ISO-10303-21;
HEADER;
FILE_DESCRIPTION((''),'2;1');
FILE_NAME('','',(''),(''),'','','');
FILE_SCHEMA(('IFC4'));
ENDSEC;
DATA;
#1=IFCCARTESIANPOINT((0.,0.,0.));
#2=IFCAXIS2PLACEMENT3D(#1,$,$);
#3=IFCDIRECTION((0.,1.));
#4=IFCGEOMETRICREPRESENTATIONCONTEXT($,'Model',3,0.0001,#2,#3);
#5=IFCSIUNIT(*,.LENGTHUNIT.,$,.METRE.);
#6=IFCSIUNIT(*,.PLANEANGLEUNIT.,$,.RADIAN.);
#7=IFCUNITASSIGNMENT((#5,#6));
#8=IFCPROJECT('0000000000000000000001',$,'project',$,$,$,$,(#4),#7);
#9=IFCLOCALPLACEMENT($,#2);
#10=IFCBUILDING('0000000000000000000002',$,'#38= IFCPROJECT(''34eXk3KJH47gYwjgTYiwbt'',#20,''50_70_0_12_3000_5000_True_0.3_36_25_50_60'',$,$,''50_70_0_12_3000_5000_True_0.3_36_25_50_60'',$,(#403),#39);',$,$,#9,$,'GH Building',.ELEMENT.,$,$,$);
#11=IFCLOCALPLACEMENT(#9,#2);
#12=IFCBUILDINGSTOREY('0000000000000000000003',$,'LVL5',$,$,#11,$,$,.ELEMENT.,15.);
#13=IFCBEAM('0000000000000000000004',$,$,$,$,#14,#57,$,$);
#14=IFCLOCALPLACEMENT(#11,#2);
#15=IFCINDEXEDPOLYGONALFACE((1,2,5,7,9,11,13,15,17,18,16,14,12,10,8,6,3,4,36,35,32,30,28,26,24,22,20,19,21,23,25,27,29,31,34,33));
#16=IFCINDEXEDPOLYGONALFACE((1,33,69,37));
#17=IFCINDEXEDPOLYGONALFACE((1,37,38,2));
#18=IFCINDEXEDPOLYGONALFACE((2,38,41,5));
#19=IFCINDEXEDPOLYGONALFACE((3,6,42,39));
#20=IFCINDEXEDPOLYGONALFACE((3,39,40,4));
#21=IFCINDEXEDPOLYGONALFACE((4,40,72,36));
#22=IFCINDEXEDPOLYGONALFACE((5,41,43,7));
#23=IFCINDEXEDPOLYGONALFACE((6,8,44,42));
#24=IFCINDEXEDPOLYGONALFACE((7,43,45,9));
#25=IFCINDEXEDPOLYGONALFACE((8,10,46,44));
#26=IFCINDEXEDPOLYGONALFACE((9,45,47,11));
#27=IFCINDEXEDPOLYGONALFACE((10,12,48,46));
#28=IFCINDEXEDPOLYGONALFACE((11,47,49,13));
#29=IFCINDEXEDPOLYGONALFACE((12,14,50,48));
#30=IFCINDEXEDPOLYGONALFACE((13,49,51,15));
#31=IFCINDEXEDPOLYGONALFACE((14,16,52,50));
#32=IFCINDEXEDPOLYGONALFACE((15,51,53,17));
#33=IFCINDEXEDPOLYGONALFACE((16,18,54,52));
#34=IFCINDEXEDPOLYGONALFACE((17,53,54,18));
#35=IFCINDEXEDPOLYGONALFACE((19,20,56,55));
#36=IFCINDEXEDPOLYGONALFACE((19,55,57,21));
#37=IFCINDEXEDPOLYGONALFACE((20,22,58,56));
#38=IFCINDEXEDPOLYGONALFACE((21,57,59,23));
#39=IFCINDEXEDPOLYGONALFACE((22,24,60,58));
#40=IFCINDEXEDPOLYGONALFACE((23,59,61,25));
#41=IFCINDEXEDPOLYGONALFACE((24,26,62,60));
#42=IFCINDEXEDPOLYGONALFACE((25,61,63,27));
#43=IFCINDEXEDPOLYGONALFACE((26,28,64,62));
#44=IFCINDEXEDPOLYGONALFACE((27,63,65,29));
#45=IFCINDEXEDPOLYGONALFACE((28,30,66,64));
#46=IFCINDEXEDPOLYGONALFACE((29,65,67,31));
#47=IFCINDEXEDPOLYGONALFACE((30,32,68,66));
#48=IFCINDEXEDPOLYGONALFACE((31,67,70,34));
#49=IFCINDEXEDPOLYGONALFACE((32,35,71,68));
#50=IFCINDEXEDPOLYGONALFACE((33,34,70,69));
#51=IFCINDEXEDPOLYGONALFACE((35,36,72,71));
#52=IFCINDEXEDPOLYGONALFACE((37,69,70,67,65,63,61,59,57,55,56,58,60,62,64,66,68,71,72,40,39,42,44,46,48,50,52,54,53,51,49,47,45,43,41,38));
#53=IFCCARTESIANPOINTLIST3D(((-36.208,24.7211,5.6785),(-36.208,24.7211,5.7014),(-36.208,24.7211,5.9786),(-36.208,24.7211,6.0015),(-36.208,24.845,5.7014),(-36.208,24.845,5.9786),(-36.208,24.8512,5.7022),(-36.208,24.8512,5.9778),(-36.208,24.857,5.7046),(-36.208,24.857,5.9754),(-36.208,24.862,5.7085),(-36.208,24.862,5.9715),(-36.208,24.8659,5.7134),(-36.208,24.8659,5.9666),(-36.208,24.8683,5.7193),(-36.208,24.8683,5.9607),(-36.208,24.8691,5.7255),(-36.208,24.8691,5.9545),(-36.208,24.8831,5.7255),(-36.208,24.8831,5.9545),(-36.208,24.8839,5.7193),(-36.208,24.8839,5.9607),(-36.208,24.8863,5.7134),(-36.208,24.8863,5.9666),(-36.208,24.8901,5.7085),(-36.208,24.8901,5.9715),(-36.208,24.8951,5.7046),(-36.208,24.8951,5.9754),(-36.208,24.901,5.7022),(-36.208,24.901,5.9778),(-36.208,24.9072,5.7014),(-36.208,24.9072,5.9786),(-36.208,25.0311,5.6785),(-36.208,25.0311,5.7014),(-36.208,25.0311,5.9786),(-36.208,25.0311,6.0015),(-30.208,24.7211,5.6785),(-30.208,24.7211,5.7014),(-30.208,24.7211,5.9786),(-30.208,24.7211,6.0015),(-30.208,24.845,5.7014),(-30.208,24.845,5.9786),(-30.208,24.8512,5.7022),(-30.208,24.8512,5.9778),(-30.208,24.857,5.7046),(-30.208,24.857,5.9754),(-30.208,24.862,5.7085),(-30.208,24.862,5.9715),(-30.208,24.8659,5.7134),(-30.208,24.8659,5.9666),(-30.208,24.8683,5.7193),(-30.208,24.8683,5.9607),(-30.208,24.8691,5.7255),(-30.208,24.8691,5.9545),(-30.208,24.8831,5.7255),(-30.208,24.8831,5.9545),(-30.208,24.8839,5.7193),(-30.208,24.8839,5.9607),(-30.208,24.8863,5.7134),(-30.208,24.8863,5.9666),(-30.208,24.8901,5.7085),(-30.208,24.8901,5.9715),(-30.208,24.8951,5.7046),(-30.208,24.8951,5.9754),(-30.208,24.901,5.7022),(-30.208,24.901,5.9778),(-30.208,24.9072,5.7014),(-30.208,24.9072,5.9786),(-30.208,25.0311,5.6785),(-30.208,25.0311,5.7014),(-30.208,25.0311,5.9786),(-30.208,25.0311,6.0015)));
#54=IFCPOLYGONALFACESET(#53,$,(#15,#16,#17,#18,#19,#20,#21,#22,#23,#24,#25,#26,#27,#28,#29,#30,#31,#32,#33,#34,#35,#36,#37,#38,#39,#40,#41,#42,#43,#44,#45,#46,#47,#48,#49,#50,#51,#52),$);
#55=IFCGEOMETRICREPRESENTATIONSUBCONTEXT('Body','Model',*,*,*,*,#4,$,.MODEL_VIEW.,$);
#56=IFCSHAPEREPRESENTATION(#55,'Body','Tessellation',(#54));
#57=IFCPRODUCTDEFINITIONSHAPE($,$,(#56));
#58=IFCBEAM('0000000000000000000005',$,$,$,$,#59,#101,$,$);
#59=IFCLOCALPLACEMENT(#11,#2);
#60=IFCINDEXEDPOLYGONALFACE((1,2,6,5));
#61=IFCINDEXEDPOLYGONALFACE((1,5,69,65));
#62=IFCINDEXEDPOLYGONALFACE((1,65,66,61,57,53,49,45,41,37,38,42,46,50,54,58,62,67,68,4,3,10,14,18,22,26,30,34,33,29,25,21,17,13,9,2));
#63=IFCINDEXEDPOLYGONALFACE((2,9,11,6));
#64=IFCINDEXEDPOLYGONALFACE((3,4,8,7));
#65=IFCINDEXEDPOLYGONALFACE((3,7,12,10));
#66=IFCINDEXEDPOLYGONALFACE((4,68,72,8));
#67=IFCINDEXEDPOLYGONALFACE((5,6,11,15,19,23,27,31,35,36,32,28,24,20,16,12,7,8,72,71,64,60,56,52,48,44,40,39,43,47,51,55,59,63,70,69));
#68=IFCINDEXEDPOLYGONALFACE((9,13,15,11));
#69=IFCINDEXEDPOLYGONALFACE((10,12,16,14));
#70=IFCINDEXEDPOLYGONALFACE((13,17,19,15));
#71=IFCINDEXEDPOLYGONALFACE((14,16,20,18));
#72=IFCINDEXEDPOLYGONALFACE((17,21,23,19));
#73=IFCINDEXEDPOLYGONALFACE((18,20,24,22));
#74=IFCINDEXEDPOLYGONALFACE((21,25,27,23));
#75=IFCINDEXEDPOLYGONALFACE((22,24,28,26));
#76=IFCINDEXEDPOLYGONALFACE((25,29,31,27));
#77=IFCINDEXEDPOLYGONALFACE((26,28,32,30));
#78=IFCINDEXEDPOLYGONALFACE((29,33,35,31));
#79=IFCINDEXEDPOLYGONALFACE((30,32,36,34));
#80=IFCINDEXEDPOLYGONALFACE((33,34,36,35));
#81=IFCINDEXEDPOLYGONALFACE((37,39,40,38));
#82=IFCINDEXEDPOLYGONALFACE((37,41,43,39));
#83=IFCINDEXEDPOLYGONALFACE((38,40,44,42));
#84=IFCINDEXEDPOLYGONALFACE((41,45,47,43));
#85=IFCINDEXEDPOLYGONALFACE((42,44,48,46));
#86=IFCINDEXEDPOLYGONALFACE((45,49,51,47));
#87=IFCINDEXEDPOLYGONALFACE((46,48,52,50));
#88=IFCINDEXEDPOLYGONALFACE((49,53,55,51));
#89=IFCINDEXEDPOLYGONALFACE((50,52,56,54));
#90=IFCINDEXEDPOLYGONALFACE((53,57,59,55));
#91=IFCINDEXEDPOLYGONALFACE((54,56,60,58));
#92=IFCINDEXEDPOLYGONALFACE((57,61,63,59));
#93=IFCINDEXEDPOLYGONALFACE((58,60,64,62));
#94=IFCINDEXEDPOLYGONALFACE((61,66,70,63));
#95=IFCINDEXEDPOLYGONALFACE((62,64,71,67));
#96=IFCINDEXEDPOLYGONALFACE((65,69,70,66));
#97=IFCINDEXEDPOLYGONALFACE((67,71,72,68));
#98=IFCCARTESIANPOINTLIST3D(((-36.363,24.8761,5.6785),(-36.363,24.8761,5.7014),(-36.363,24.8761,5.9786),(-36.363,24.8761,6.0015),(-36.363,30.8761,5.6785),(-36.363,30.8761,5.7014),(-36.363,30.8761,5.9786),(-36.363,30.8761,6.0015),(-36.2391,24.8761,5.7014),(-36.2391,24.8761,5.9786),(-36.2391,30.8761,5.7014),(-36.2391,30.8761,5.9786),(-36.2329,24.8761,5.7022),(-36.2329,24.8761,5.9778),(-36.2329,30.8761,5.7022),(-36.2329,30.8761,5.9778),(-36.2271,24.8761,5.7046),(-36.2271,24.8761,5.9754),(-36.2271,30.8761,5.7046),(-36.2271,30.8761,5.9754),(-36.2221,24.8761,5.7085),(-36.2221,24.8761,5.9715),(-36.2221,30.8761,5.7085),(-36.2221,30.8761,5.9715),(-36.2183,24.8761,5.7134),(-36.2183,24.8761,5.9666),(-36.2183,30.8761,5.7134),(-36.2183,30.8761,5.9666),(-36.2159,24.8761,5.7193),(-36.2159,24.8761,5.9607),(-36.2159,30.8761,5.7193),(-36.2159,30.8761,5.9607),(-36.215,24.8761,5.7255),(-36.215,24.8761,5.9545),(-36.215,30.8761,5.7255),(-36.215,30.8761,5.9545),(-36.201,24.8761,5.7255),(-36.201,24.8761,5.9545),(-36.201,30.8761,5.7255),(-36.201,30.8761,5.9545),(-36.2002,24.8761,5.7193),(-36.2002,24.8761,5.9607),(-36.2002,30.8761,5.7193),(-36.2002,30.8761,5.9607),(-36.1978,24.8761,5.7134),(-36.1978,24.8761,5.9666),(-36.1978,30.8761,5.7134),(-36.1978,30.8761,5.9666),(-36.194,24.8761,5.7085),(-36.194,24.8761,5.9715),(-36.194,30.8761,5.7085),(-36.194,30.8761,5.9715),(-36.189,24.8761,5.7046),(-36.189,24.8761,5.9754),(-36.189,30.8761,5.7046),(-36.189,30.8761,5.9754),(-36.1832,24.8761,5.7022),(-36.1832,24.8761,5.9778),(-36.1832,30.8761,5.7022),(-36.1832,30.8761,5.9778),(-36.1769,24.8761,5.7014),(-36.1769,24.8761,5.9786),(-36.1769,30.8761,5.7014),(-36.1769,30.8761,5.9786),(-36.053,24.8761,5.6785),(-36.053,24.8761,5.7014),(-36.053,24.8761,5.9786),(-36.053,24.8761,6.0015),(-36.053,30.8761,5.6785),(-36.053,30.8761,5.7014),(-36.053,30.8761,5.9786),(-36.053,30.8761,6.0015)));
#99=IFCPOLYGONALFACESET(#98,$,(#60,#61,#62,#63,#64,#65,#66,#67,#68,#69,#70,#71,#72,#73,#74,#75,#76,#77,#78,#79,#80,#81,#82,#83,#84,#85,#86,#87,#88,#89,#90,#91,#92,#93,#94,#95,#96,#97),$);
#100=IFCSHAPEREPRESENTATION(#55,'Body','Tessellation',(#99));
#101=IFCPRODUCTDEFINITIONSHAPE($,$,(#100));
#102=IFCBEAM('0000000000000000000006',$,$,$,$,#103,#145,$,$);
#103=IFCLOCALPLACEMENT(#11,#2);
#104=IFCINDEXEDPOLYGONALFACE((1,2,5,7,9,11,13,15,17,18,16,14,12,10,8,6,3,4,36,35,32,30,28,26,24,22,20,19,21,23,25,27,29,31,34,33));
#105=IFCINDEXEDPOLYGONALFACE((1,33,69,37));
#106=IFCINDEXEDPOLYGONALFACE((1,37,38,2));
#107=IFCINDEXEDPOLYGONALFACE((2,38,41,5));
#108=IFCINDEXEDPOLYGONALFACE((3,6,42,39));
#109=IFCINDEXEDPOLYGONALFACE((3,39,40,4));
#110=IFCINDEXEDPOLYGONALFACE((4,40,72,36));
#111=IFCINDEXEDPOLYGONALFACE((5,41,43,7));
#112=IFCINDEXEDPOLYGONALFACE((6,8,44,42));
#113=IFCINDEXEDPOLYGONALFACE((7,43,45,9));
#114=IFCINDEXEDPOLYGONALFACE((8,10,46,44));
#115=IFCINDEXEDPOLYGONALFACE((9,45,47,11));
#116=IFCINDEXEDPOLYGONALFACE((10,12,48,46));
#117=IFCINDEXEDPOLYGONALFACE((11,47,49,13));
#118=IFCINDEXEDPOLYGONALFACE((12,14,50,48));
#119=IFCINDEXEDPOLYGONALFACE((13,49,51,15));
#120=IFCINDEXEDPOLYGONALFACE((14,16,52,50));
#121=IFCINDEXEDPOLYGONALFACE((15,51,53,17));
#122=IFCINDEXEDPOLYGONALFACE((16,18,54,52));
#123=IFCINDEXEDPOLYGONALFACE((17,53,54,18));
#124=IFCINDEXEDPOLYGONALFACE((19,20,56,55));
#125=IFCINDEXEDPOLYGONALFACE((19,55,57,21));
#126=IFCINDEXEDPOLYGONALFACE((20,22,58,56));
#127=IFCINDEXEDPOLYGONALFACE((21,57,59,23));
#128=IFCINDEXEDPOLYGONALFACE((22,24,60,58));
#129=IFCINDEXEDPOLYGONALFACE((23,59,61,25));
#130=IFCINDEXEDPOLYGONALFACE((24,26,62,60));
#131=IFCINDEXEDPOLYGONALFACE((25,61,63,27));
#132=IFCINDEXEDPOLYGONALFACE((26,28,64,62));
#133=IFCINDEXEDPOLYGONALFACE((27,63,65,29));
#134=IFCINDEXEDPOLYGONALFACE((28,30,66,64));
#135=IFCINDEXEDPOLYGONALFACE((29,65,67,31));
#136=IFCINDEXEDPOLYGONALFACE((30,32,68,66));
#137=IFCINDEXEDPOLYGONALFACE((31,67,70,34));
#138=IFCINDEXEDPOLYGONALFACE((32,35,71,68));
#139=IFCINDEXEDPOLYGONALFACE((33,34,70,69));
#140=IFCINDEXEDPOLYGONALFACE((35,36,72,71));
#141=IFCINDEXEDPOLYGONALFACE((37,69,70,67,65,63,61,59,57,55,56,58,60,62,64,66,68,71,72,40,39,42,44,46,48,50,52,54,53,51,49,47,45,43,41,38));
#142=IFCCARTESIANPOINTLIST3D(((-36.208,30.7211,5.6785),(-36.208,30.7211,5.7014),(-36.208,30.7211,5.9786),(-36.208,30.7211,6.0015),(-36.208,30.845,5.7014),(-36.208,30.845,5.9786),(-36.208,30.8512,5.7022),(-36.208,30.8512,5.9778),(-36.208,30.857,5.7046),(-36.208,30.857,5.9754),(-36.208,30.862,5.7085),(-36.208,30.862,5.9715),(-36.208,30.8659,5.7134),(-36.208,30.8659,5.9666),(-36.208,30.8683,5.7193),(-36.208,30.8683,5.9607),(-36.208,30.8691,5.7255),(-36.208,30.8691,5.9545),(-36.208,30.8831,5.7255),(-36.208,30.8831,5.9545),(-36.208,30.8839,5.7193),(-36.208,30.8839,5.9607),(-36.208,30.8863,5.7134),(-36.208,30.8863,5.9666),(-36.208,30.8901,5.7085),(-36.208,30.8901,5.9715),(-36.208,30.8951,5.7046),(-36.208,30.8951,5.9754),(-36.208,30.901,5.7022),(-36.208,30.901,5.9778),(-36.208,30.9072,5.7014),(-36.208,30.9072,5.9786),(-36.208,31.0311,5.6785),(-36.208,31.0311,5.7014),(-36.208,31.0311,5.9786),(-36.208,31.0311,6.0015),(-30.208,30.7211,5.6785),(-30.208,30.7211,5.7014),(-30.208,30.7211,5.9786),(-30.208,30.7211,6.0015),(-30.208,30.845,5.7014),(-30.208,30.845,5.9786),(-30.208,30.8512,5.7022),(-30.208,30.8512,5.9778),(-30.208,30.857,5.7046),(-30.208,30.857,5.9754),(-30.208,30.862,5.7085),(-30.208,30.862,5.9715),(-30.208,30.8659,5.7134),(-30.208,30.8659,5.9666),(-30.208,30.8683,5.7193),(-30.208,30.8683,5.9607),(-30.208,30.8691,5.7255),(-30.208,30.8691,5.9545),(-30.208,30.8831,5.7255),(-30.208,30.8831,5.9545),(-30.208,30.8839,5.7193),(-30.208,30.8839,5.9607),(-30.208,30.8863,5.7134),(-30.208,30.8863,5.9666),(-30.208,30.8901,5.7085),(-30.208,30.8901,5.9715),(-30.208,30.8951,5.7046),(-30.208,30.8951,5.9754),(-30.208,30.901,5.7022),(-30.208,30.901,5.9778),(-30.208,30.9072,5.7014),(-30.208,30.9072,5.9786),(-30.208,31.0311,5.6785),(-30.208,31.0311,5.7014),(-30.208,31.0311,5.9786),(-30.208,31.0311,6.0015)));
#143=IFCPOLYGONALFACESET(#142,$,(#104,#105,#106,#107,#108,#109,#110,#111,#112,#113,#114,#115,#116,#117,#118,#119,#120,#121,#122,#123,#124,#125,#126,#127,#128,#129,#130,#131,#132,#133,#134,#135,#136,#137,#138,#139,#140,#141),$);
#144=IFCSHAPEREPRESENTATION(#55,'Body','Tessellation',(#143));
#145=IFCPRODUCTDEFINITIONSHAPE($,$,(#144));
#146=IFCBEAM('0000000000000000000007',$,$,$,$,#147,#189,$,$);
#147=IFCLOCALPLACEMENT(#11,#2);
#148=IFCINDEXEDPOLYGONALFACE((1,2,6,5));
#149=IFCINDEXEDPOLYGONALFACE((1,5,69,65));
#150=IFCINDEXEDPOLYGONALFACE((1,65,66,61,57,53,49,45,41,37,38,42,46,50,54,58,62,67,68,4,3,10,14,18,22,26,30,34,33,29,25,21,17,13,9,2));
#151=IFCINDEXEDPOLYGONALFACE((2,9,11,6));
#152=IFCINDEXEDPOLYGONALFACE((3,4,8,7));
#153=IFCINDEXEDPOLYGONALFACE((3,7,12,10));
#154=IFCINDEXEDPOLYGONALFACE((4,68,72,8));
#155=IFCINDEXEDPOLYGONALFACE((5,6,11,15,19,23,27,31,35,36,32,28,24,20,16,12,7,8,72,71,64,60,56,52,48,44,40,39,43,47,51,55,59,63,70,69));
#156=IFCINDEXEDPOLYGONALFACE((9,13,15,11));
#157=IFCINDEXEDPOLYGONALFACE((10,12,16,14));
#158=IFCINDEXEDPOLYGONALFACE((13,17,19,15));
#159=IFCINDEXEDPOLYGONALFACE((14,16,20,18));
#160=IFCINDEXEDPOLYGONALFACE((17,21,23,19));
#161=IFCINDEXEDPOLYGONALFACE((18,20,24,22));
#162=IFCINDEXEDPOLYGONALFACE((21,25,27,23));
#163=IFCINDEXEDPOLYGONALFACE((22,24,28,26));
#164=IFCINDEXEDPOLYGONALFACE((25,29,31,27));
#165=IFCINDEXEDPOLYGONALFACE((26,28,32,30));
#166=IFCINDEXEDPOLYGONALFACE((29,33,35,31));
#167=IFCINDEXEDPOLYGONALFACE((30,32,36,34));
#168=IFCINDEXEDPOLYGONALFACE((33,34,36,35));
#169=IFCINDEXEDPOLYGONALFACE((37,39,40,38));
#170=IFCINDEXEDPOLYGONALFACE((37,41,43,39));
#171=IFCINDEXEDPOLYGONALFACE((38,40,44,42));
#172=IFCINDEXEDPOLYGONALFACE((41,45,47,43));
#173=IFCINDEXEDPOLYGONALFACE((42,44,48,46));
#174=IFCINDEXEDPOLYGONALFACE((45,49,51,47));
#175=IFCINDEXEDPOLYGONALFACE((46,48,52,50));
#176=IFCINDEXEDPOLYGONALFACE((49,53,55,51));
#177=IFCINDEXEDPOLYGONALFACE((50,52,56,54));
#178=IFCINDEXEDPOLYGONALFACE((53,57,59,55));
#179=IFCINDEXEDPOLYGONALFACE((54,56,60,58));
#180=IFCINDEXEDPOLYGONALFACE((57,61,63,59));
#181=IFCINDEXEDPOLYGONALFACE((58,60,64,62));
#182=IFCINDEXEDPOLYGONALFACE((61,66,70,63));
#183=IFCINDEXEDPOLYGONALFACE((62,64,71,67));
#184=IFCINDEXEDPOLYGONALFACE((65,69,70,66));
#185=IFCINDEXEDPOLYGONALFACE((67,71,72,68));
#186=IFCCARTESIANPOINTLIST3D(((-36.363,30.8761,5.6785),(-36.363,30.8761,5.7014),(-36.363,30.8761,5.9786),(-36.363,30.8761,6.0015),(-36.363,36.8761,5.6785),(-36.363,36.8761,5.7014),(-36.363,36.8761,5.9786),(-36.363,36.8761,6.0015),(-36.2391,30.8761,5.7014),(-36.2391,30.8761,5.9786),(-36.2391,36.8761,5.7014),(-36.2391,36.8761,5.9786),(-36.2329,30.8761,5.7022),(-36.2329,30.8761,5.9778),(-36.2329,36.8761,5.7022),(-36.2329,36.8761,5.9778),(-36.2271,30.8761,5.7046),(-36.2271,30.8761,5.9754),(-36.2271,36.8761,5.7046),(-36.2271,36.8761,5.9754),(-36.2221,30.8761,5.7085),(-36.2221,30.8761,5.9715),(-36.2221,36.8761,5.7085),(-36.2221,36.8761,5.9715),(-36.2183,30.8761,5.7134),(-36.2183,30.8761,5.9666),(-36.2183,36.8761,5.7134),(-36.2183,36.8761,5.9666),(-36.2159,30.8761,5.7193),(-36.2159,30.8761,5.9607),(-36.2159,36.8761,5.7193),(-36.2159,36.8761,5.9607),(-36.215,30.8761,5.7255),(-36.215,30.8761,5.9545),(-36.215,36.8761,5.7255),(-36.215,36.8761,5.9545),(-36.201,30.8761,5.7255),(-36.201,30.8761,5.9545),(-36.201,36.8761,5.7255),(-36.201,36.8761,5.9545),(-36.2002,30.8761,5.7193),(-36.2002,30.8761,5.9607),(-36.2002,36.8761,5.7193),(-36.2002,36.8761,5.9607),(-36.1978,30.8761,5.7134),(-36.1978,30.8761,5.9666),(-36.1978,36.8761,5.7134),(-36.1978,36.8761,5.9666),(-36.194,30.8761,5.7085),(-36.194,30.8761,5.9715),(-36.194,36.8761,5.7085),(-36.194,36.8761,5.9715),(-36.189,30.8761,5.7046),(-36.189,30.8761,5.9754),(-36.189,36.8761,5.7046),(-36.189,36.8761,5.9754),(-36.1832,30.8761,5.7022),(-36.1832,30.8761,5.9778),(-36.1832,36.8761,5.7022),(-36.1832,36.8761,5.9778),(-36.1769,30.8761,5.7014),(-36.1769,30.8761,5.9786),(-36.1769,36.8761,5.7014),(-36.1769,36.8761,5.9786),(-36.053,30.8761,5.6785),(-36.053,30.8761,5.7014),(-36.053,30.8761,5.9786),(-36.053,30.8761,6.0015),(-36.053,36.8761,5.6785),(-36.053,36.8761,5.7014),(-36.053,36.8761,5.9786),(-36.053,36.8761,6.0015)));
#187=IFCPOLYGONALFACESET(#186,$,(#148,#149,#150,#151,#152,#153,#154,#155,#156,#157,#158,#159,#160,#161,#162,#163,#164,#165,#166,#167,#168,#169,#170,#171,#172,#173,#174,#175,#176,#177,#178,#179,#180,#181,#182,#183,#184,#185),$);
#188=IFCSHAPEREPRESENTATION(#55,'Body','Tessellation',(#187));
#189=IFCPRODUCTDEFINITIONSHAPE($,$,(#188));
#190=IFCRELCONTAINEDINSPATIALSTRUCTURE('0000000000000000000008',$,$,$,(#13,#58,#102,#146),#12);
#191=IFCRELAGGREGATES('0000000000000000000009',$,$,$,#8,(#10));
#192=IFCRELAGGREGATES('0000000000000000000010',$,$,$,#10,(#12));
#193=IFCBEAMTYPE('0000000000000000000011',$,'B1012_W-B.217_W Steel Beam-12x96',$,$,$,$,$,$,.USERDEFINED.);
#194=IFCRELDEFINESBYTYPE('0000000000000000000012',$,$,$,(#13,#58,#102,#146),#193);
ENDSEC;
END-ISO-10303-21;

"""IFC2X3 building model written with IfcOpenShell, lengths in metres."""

from ifc_helpers import new_model, si_unit, direction, frame, origin, origin_2d, place, context, subcontext, project, spatial, i_section, extrude, type_object, element, save


model = new_model("IFC2X3")

# Units and contexts
model_context = context("Model", 3, precision=0.0001, world=origin(), true_north=direction((0.0, 1.0)))
body_context = subcontext(model_context, "Body", "Model", "MODEL_VIEW")
ifc_project = project(units=[si_unit("LENGTHUNIT", "METRE"), si_unit("PLANEANGLEUNIT", "RADIAN")], contexts=[model_context])

# Building, storey
building_placement = place(None, origin())
building = spatial("IfcBuilding", under=ifc_project, at=building_placement, Name="#38= IFCPROJECT('34eXk3KJH47gYwjgTYiwbt',#20,'50_70_0_12_3000_5000_True_0.3_36_25_50_60',$,$,'50_70_0_12_3000_5000_True_0.3_36_25_50_60',$,(#403),#39);", LongName="GH Building", CompositionType="ELEMENT")
storey_placement = place(building_placement, origin())
storey = spatial("IfcBuildingStorey", under=building, at=storey_placement, Name="LVL5", CompositionType="ELEMENT", Elevation=15.0)

# Beams
beam_type = type_object("IfcBeamType", Name="B1012_W-B.217_W Steel Beam-12x96", PredefinedType="USERDEFINED")
for number, where, z_axis, x_axis in (
    (1, (-36.208, 24.8761, 5.84), (1.0, 0.0, 0.0), (0.0, 1.0, 0.0)),
    (2, (-36.208, 24.8761, 5.84), (0.0, 1.0, 0.0), (-1.0, 0.0, 0.0)),
    (3, (-36.208, 30.8761, 5.84), (1.0, 0.0, 0.0), (0.0, 1.0, 0.0)),
    (4, (-36.208, 30.8761, 5.84), (0.0, 1.0, 0.0), (-1.0, 0.0, 0.0)),
):
    element("IfcBeam", number, at=place(storey_placement, frame(where, z_axis=z_axis, x_axis=x_axis)), inside=storey, type_object=beam_type, context=body_context, shape_type="SweptSolid", body=[
        extrude(i_section(OverallWidth=0.31, OverallDepth=0.323, WebThickness=0.014, FlangeThickness=0.0229, FilletRadius=0.0241, at=origin_2d()), origin(), (0.0, 0.0, 1.0), 6.0),
    ])

save(model, "model.ifc")
